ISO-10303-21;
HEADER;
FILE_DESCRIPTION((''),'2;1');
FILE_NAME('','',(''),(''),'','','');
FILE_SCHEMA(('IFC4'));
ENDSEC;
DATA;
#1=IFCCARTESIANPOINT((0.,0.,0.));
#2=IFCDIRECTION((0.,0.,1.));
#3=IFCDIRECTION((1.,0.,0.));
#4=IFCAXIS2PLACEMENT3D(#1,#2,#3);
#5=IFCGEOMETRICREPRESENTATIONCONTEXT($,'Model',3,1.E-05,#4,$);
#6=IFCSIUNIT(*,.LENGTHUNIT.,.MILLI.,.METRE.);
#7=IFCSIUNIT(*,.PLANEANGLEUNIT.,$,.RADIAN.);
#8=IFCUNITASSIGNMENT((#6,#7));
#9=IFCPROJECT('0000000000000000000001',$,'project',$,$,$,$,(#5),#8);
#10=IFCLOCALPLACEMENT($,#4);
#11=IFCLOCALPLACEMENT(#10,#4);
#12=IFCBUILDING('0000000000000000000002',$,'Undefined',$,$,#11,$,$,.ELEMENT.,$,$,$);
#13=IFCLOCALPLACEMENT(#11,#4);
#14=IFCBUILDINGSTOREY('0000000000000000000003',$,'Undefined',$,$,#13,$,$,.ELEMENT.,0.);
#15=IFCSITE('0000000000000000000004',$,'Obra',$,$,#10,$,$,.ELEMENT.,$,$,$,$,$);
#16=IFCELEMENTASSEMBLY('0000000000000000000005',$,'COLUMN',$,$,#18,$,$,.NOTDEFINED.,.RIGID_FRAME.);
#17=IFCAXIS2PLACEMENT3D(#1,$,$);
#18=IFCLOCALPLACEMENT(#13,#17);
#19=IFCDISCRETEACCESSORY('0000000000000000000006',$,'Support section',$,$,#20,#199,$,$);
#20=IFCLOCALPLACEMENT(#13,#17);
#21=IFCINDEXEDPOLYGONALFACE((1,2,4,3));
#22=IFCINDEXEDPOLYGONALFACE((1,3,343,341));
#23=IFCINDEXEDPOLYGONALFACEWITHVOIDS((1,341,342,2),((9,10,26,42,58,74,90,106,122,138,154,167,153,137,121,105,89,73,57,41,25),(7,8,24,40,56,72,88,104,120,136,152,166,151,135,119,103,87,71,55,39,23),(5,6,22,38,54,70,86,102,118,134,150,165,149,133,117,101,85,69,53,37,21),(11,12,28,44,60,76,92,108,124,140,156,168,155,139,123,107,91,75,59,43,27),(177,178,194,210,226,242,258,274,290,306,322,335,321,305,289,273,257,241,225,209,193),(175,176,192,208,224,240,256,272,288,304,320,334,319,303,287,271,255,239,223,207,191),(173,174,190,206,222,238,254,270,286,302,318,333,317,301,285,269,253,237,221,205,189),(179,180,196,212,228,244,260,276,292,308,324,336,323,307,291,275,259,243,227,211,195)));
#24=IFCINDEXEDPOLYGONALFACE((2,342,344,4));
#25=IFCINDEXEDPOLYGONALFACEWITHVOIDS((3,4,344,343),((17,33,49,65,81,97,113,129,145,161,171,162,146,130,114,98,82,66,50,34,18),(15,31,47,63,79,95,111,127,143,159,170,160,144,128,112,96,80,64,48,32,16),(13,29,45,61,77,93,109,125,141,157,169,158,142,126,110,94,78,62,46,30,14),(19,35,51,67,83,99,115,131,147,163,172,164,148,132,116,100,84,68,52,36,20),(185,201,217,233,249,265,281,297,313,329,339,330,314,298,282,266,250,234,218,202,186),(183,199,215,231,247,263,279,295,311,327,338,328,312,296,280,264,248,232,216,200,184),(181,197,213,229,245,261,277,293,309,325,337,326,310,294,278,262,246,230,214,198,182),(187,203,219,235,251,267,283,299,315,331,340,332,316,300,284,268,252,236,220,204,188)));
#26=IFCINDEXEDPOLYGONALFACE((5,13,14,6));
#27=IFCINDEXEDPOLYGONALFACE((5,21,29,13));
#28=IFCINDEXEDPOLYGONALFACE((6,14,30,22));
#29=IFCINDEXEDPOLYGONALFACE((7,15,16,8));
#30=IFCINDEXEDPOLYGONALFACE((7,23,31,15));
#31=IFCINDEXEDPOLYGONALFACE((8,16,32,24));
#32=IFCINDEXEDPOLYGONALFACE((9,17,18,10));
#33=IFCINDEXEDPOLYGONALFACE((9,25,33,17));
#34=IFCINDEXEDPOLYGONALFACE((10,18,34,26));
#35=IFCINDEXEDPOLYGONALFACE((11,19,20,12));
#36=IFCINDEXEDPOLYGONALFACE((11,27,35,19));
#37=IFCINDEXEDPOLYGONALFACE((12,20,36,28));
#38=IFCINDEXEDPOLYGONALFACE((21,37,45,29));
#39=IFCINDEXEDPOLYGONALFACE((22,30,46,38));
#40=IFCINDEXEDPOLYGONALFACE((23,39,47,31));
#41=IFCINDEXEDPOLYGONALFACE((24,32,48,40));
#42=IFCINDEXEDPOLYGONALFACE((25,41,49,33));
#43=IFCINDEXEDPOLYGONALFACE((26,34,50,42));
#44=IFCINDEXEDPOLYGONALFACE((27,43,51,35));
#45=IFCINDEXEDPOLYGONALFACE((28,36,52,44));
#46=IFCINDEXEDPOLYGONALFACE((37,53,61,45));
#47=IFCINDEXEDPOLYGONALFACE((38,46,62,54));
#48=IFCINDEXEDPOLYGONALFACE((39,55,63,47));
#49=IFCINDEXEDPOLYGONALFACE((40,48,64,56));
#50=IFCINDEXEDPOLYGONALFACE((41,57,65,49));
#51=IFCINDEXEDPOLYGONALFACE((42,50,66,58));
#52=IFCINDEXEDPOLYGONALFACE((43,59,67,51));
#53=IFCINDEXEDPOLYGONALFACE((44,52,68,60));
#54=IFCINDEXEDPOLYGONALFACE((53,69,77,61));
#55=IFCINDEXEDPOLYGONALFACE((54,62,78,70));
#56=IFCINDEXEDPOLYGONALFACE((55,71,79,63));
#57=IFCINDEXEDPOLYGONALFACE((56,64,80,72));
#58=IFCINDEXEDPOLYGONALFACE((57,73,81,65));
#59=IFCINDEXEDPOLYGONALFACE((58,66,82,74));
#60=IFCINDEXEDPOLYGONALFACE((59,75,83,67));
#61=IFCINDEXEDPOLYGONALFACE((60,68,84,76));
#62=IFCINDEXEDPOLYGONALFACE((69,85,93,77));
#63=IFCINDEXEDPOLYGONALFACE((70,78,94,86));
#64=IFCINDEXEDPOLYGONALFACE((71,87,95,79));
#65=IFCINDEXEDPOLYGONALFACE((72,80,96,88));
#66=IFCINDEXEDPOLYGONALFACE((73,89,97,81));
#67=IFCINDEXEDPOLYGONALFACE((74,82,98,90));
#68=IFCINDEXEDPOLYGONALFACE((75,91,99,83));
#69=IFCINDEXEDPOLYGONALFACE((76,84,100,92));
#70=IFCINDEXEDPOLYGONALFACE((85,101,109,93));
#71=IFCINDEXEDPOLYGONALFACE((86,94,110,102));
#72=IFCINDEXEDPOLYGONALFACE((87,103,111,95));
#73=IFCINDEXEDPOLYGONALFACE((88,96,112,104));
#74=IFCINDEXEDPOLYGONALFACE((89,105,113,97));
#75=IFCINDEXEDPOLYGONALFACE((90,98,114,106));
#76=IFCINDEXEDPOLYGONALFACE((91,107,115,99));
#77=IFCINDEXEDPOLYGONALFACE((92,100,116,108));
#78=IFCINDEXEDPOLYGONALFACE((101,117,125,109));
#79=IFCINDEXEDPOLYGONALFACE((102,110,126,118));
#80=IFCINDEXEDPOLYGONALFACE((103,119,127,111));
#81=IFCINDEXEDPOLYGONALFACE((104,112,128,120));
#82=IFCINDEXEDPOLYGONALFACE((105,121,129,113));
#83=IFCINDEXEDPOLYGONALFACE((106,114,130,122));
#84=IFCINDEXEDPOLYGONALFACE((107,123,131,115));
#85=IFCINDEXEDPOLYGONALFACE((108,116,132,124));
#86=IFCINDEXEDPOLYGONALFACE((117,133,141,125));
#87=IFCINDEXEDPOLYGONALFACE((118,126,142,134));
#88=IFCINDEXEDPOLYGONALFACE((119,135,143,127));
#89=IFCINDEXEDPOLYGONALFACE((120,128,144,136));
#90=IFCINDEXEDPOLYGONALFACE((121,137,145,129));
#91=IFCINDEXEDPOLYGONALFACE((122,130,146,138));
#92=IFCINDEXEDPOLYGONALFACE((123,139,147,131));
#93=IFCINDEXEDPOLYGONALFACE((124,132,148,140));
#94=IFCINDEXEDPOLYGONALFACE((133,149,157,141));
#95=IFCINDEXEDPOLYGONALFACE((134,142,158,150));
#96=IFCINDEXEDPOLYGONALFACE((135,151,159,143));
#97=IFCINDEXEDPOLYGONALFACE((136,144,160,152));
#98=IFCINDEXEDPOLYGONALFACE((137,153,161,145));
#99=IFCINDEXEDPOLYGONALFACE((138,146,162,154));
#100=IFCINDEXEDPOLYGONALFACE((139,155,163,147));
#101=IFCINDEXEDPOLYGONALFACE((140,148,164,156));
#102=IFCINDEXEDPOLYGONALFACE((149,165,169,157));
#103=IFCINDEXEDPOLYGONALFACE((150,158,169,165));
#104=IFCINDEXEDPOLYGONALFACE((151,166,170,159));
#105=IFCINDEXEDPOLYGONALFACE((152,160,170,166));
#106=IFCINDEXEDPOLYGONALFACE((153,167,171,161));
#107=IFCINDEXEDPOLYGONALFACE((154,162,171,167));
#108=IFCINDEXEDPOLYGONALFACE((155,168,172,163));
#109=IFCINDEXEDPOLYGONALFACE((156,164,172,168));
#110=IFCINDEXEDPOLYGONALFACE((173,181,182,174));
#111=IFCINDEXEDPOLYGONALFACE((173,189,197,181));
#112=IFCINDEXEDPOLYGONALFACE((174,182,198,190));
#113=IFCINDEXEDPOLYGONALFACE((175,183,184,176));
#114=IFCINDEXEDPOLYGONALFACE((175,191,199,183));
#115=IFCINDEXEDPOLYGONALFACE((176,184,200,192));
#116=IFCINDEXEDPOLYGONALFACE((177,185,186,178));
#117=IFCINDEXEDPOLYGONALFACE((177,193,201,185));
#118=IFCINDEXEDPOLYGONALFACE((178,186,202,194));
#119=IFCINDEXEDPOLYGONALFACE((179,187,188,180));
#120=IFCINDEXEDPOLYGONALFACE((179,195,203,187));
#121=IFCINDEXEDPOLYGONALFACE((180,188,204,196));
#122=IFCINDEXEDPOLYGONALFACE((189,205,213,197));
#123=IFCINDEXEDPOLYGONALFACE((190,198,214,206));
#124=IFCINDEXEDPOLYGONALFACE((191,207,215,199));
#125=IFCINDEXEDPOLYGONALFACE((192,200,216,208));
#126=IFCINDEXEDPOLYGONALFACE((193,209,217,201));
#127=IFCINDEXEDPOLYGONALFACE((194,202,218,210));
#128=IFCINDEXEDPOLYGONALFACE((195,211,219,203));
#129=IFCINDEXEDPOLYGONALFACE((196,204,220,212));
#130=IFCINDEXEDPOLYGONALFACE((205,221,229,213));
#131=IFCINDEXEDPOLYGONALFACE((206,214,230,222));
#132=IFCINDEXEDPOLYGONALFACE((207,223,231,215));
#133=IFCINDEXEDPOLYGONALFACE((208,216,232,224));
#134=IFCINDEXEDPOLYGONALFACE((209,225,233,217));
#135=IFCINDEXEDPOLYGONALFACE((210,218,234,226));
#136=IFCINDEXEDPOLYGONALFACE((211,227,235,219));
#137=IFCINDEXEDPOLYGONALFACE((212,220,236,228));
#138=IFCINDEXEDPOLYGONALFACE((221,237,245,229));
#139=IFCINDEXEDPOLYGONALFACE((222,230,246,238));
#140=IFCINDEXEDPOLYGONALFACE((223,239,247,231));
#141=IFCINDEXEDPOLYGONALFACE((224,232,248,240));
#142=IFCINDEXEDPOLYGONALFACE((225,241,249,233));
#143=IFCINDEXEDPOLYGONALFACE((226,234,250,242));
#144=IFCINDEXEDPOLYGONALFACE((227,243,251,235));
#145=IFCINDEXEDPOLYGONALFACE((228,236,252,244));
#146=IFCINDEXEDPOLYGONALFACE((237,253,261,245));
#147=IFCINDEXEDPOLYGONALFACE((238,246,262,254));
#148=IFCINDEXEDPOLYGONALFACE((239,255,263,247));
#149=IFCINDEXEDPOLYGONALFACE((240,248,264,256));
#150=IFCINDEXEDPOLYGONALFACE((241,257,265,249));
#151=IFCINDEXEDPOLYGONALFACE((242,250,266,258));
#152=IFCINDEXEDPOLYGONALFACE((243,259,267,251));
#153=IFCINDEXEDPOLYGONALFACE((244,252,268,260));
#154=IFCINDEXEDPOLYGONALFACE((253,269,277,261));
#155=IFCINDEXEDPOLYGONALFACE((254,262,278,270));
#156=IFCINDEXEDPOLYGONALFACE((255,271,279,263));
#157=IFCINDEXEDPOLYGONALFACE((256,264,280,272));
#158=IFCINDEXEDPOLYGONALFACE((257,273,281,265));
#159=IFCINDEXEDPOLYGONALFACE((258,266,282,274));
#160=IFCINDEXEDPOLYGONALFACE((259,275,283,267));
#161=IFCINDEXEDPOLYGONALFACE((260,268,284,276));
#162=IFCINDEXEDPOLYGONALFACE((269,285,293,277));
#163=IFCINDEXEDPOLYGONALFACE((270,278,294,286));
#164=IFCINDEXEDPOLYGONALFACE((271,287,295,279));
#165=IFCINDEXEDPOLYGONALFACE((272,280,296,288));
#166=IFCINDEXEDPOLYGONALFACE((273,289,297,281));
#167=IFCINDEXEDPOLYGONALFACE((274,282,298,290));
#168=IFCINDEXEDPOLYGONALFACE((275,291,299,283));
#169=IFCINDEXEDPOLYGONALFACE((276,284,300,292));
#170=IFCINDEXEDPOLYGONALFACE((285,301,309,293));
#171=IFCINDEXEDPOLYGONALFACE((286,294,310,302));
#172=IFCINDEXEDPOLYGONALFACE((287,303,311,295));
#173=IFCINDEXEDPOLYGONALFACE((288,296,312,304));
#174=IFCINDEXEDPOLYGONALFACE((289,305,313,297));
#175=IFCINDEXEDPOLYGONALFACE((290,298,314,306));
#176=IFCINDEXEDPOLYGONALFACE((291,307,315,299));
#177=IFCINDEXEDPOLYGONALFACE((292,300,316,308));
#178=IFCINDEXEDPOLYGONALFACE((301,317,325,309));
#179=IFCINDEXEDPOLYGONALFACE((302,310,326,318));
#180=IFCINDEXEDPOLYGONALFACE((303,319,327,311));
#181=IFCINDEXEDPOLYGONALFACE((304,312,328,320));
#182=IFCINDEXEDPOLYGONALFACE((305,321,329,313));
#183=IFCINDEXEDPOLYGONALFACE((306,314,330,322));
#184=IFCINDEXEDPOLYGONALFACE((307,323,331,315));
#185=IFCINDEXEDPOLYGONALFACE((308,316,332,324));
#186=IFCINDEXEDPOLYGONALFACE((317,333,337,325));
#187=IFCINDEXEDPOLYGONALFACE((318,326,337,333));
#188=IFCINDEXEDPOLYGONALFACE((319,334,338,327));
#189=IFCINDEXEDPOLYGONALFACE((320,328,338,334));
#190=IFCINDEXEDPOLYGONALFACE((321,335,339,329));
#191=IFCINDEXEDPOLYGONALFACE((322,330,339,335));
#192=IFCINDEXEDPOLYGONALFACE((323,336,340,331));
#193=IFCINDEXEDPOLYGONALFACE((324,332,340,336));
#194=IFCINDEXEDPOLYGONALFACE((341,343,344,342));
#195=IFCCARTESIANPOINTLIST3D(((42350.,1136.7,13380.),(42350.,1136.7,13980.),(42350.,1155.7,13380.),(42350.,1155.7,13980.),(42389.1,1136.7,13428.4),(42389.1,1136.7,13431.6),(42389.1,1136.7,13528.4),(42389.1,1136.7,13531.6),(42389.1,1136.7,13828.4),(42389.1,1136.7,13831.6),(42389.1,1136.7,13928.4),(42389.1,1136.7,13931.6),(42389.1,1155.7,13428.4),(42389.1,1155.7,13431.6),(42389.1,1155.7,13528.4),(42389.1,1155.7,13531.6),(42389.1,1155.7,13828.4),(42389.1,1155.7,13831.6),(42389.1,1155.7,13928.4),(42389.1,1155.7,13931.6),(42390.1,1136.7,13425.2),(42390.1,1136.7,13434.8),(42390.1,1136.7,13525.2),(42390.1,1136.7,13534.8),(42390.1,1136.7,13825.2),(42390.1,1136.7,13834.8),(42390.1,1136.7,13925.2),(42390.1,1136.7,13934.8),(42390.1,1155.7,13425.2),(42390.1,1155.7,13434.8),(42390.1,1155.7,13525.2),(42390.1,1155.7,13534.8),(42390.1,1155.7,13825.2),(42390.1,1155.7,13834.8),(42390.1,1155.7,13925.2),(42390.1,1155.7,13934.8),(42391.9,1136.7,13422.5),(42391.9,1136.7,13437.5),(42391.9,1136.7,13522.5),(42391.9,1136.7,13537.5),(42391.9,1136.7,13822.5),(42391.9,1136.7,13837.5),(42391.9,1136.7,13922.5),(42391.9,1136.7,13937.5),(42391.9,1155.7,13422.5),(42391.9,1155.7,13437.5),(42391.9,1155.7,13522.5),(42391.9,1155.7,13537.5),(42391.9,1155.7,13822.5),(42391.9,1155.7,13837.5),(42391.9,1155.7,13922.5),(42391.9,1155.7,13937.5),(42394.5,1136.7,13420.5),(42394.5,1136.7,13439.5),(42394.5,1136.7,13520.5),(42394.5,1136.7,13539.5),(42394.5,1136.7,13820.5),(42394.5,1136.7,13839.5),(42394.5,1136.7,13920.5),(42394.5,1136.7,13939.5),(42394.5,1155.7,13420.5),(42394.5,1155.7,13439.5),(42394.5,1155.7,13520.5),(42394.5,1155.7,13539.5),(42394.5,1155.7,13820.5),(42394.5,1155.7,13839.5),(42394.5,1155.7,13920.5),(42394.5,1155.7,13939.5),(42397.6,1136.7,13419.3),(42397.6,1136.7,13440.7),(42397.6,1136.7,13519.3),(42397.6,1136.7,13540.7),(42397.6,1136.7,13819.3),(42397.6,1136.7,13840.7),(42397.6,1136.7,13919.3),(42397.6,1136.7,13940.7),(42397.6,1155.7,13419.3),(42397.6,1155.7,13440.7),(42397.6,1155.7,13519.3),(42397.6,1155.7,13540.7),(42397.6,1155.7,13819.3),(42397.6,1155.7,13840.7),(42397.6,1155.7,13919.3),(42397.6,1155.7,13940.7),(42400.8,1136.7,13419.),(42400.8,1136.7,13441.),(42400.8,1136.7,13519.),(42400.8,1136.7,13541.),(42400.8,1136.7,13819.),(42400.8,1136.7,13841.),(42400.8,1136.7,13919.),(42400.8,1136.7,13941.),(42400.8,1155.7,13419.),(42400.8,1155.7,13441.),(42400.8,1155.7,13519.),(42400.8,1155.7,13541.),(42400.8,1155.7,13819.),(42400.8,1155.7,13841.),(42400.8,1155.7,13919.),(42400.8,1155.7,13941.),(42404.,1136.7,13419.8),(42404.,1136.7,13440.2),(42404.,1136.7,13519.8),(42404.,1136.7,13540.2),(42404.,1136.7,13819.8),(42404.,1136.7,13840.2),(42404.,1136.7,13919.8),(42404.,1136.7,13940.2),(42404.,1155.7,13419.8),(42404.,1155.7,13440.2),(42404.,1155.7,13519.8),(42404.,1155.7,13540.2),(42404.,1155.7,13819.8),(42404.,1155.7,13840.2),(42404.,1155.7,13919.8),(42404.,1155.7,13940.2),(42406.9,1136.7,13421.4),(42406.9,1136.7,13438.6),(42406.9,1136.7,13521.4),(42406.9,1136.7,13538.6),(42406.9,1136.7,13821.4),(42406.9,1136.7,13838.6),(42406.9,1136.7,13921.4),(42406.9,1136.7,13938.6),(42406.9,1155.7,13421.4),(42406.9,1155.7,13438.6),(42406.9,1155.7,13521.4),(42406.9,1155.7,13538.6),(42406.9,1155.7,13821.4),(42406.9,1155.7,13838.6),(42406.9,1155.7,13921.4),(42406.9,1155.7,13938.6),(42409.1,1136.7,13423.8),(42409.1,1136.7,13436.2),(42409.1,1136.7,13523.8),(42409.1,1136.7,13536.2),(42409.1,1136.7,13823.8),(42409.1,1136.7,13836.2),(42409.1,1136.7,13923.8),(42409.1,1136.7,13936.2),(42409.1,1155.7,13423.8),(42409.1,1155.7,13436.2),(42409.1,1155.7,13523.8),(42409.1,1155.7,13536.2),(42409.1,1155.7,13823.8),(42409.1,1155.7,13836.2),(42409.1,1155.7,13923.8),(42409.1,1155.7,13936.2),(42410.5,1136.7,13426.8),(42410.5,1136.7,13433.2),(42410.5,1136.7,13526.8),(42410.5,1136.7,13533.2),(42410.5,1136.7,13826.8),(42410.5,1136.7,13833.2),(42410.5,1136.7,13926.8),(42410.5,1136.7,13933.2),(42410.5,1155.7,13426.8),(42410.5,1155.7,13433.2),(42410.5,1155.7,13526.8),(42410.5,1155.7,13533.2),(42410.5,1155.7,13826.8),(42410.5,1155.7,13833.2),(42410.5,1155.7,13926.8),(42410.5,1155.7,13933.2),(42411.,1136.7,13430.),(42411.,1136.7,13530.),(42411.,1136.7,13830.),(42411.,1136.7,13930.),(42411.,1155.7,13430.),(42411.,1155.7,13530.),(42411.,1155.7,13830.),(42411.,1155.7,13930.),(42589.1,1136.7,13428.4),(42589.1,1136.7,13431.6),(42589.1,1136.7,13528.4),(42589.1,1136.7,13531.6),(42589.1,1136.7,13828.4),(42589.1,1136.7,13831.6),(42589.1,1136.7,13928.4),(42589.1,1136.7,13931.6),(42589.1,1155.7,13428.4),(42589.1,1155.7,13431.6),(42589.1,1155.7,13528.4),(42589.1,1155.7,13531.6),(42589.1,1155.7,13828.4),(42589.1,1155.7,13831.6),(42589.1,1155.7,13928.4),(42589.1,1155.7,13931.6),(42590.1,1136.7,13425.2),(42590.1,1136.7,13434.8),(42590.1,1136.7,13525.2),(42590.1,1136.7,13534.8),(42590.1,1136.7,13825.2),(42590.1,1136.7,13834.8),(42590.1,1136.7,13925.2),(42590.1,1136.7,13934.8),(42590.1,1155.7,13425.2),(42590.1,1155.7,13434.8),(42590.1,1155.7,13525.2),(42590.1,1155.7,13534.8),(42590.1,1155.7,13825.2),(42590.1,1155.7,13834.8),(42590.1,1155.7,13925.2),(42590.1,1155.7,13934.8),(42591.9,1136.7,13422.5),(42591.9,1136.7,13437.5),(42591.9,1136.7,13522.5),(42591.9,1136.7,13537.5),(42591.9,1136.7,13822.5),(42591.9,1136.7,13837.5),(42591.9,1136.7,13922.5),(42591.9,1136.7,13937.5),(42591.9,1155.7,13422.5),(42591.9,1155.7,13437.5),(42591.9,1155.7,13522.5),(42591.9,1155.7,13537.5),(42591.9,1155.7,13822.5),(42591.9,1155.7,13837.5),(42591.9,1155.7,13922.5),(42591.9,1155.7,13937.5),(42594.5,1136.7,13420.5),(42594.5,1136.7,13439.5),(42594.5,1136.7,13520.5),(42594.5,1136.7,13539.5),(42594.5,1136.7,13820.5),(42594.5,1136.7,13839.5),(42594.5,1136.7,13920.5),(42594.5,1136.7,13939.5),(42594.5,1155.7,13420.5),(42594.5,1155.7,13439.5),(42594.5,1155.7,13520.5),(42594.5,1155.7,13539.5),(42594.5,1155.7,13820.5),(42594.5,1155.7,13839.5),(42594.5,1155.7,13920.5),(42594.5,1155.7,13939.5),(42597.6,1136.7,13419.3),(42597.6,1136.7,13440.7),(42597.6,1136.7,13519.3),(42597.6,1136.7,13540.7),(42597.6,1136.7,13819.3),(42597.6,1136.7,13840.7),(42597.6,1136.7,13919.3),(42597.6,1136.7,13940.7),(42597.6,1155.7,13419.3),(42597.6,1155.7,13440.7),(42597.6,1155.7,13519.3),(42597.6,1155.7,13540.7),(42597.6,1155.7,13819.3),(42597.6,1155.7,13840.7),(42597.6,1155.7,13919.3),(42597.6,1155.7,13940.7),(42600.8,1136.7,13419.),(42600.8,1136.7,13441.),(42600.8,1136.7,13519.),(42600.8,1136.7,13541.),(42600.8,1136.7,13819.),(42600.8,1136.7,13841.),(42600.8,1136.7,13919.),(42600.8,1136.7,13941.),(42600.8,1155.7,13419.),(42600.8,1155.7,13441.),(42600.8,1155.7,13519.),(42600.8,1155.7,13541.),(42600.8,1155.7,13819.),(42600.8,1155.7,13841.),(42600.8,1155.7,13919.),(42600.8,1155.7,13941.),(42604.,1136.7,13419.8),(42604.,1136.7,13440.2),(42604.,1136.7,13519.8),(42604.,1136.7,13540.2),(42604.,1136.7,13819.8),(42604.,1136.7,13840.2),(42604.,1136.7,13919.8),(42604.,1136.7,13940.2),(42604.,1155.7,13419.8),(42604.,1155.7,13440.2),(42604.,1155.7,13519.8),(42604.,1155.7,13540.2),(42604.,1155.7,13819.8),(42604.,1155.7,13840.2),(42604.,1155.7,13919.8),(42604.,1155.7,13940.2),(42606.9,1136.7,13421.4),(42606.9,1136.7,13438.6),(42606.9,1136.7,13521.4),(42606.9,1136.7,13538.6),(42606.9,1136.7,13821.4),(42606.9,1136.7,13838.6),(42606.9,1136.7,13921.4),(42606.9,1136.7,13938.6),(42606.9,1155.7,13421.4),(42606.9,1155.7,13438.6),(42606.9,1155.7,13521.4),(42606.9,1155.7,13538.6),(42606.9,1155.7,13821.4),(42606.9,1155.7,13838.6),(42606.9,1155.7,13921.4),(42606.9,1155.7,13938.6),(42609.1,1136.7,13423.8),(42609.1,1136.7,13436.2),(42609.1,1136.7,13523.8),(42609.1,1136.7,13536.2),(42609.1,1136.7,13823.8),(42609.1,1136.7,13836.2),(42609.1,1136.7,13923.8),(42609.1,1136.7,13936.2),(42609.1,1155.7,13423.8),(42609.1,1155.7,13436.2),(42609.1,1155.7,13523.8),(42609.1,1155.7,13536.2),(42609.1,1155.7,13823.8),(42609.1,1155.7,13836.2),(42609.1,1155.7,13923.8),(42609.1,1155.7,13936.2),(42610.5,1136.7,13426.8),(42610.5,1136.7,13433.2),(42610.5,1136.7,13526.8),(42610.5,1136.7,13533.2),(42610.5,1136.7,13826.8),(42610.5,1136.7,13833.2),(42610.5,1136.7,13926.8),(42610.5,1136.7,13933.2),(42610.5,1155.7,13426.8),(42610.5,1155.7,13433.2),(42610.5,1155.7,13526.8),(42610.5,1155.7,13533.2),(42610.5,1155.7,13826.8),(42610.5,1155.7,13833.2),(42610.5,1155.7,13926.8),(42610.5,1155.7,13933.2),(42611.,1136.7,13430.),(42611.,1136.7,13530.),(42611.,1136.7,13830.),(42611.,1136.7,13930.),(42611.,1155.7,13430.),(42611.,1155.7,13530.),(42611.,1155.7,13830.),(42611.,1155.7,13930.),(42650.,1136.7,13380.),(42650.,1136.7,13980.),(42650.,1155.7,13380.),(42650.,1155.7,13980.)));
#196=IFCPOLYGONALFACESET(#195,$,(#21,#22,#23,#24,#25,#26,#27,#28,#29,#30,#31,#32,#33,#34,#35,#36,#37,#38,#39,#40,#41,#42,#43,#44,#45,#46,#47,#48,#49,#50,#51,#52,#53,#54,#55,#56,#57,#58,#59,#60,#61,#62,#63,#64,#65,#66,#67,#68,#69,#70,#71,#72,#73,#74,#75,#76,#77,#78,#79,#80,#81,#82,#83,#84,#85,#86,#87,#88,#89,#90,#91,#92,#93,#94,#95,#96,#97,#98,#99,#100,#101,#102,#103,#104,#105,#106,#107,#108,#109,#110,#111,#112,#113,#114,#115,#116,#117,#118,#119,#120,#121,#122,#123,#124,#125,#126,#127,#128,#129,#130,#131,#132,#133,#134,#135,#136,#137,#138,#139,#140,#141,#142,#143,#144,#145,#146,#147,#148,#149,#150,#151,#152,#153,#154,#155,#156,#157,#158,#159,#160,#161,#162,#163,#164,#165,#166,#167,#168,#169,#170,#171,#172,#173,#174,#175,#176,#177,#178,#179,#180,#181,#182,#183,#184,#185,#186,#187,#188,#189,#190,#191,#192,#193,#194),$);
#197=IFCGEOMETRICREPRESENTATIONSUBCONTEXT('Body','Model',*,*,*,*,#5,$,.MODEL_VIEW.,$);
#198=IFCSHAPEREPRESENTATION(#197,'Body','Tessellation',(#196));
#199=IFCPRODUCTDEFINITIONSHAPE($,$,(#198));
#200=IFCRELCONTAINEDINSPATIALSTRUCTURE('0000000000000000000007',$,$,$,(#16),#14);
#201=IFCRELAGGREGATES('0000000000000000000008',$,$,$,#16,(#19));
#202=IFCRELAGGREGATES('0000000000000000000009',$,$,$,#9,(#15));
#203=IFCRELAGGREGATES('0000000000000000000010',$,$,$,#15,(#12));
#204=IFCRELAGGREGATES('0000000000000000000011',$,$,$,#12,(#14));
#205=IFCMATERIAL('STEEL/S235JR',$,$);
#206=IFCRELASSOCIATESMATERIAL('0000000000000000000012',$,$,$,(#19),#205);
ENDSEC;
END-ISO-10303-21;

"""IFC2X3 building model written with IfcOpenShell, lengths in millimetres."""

from ifc_helpers import new_model, si_unit, frame, origin_with_axes, origin_2d_with_axis, place, context, subcontext, project, spatial, rectangle, circle, extrude, source, transform, mapped, material, element, aggregate, save


model = new_model("IFC2X3")

# Units and contexts
model_context = context("Model", 3, precision=1e-05, world=origin_with_axes())
body_context = subcontext(model_context, "Body", "Model", "MODEL_VIEW")
ifc_project = project(units=[si_unit("LENGTHUNIT", "METRE", prefix="MILLI"), si_unit("PLANEANGLEUNIT", "RADIAN")], contexts=[model_context])

# Site, building, storey
site_placement = place(None, origin_with_axes())
site = spatial("IfcSite", under=ifc_project, at=site_placement, Name="Obra", CompositionType="ELEMENT")
building_placement = place(site_placement, origin_with_axes())
building = spatial("IfcBuilding", under=site, at=building_placement, Name="Undefined", CompositionType="ELEMENT")
storey_placement = place(building_placement, origin_with_axes())
storey = spatial("IfcBuildingStorey", under=building, at=storey_placement, Name="Undefined", CompositionType="ELEMENT", Elevation=0.0)

# Element assembly
assembly_1_placement = place(storey_placement, origin_with_axes())
assembly_1 = element("IfcElementAssembly", 1, at=assembly_1_placement, inside=storey, Name="COLUMN", AssemblyPlace="NOTDEFINED", PredefinedType="RIGID_FRAME")
ifc_material_1 = material(Name="STEEL/S235JR")

# Discrete accessory, opening
discrete_accessory_1_placement = place(assembly_1_placement, frame((42650.0, 1146.2, 13680.0), z_axis=(0.0, 0.0, 1.0), x_axis=(-1.0, 0.0, 0.0)))
discrete_accessory_1 = element("IfcDiscreteAccessory", 2, at=discrete_accessory_1_placement, material=ifc_material_1, Name="Support section", context=body_context, shape_type="SweptSolid", body=[
    extrude(rectangle(XDim=19.0, YDim=600.0, at=origin_2d_with_axis()), frame((300.0, 0.0, 0.0), z_axis=(-1.0, 0.0, 0.0), x_axis=(0.0, -1.0, 0.0)), (0.0, 0.0, 1.0), 300.0),
])
shared_shape_1 = source(origin_with_axes(), body_context, "Body", "SweptSolid", [
    extrude(circle(Radius=11.0, at=origin_2d_with_axis()), frame((0.0, -19.1, 0.0), z_axis=(0.0, 1.0, 0.0), x_axis=(1.0, 0.0, 0.0)), (0.0, 0.0, 1.0), 19.2),
])
opening_1_placement = place(assembly_1_placement, frame((42350.0, 1155.7, 13680.0), z_axis=(0.0, 0.0, 1.0), x_axis=(1.0, 0.0, 0.0)))
element("IfcOpeningElement", 3, at=opening_1_placement, cuts=discrete_accessory_1, ObjectType="Opening", context=body_context, shape_type="MappedRepresentation", body=[
    mapped(shared_shape_1, transform((50.0, 0.0, -250.0))),
    mapped(shared_shape_1, transform((50.0, 0.0, -150.0))),
    mapped(shared_shape_1, transform((50.0, 0.0, 150.0))),
    mapped(shared_shape_1, transform((50.0, 0.0, 250.0))),
    mapped(shared_shape_1, transform((250.0, 0.0, -250.0))),
    mapped(shared_shape_1, transform((250.0, 0.0, -150.0))),
    mapped(shared_shape_1, transform((250.0, 0.0, 150.0))),
    mapped(shared_shape_1, transform((250.0, 0.0, 250.0))),
])
aggregate(assembly_1, [discrete_accessory_1])

save(model, "model.ifc")
